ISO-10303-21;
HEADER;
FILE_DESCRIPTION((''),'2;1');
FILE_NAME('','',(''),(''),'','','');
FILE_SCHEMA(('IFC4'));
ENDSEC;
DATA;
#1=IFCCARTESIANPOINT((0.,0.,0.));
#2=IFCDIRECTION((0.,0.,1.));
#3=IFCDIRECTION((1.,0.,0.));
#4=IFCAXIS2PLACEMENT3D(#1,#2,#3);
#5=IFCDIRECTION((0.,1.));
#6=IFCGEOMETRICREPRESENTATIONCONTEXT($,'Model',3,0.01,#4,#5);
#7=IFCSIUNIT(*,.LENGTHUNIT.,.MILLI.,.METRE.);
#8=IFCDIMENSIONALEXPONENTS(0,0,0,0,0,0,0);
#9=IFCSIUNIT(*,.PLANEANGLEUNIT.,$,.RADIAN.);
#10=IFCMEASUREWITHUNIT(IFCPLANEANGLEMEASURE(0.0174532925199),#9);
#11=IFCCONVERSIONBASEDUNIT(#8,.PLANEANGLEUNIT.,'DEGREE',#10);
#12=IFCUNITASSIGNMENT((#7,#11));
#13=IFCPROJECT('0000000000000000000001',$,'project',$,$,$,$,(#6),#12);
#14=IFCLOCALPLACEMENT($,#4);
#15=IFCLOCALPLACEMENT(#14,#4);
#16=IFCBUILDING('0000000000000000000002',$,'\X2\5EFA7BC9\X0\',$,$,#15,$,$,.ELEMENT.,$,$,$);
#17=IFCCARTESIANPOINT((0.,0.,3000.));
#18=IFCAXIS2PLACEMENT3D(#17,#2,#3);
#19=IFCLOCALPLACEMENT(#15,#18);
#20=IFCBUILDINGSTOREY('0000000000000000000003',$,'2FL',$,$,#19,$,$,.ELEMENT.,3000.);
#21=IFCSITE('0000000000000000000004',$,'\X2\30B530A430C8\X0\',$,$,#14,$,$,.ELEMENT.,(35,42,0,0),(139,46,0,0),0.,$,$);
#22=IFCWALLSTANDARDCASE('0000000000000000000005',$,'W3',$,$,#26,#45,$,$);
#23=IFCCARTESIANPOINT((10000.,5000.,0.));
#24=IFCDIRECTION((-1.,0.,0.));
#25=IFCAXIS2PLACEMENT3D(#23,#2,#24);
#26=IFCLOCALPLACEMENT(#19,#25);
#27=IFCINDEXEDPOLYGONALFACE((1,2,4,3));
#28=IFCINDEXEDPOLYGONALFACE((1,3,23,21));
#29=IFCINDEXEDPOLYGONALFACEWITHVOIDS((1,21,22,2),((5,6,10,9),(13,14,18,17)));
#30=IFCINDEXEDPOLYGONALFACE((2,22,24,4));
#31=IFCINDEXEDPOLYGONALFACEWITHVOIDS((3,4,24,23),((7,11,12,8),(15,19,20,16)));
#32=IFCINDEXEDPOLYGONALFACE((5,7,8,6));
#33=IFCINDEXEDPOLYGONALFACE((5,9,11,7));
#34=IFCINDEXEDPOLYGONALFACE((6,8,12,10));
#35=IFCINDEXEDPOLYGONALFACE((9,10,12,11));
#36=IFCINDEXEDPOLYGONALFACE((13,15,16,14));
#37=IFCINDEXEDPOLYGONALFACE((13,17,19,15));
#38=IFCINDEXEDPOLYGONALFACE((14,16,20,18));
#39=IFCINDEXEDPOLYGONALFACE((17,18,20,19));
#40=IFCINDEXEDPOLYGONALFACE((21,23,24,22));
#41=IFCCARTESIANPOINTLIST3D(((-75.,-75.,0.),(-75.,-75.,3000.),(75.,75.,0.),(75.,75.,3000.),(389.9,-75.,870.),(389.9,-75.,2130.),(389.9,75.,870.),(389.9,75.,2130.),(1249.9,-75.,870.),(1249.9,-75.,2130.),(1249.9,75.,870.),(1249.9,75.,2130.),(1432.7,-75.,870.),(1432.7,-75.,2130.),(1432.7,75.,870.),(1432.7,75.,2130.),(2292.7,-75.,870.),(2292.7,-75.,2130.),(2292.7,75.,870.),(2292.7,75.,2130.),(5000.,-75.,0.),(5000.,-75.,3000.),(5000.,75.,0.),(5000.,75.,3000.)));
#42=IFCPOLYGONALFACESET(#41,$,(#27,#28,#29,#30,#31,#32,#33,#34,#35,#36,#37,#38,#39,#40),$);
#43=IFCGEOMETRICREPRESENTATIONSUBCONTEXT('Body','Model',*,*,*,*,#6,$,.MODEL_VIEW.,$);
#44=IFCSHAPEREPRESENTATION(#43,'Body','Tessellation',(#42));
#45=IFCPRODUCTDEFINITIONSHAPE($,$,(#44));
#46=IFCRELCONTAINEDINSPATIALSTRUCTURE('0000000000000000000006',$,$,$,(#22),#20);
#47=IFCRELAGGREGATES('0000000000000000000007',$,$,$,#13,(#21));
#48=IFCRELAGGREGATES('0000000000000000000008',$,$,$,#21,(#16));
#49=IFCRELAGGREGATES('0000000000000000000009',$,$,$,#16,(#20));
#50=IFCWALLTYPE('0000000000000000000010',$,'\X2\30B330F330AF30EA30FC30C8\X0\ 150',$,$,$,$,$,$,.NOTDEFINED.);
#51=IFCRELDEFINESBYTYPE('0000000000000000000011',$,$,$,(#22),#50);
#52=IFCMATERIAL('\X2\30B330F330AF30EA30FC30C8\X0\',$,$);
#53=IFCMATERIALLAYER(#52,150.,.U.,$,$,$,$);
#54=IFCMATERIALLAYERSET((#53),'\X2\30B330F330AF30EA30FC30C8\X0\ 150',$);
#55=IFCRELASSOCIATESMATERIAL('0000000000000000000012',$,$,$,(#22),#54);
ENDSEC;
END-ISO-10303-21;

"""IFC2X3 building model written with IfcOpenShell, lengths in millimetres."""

from ifc_helpers import new_model, entity, si_unit, converted_unit, direction, frame, origin_with_axes, origin_2d_with_axis, place, context, subcontext, project, spatial, polyline, rectangle, outline, extrude, material, layer, layer_set, layer_usage, type_object, element, save


model = new_model("IFC2X3")

# Units and contexts
model_context = context("Model", 3, precision=0.01, world=origin_with_axes(), true_north=direction((0.0, 1.0)))
body_context = subcontext(model_context, "Body", "Model", "MODEL_VIEW")
ifc_project = project(units=[si_unit("LENGTHUNIT", "METRE", prefix="MILLI"), converted_unit("PLANEANGLEUNIT", "DEGREE", entity("IfcPlaneAngleMeasure", 0.0174532925199), si_unit("PLANEANGLEUNIT", "RADIAN"), dimensions=[0, 0, 0, 0, 0, 0, 0])], contexts=[model_context])

# Site, building, storey
site_placement = place(None, origin_with_axes())
site = spatial("IfcSite", under=ifc_project, at=site_placement, Name="サイト", CompositionType="ELEMENT", RefLatitude=(35, 42, 0, 0), RefLongitude=(139, 46, 0, 0), RefElevation=0.0)
building_placement = place(site_placement, origin_with_axes())
building = spatial("IfcBuilding", under=site, at=building_placement, Name="建築", CompositionType="ELEMENT")
storey_placement = place(building_placement, frame((0.0, 0.0, 3000.0), z_axis=(0.0, 0.0, 1.0), x_axis=(1.0, 0.0, 0.0)))
storey = spatial("IfcBuildingStorey", under=building, at=storey_placement, Name="2FL", CompositionType="ELEMENT", Elevation=3000.0)

# Shared definitions
ifc_material_1 = material(Name="コンクリート")

# Shared definitions
ifc_layer_1 = layer(ifc_material_1, 150.0, ventilated="UNKNOWN")
ifc_layer_set_1 = layer_set([ifc_layer_1], Name="コンクリート 150")
wall_type_1 = type_object("IfcWallType", Name="コンクリート 150", PredefinedType="NOTDEFINED")

# Wall, openings
ifc_layer_usage_1 = layer_usage(ifc_layer_set_1, "AXIS2", "POSITIVE", -75.0)
wall_1_placement = place(storey_placement, frame((10000.0, 5000.0, 0.0), z_axis=(0.0, 0.0, 1.0), x_axis=(-1.0, 0.0, 0.0)))
wall_1 = element("IfcWallStandardCase", 1, at=wall_1_placement, inside=storey, type_object=wall_type_1, material=ifc_layer_usage_1, Name="W3", context=body_context, shape_type="SweptSolid", body=[
    extrude(outline(polyline([(-75.0, -75.0), (5000.0, -75.0), (5000.0, 75.0), (75.0, 75.0), (-75.0, -75.0)])), origin_with_axes(), (0.0, 0.0, 1.0), 3000.0),
])
opening_1_placement = place(wall_1_placement, frame((819.9, 0.0, 900.0), z_axis=(0.0, 0.0, 1.0), x_axis=(1.0, 0.0, 0.0)))
element("IfcOpeningElement", 2, at=opening_1_placement, cuts=wall_1, context=body_context, shape_type="SweptSolid", body=[
    extrude(rectangle(XDim=860.0, YDim=1260.0, at=origin_2d_with_axis()), frame((0.0, -195.0, 600.0), z_axis=(0.0, 1.0, 0.0), x_axis=(-1.0, 0.0, 0.0)), (0.0, 0.0, 1.0), 390.0),
])
opening_2_placement = place(wall_1_placement, frame((1862.7, 0.0, 900.0), z_axis=(0.0, 0.0, 1.0), x_axis=(1.0, 0.0, 0.0)))
element("IfcOpeningElement", 3, at=opening_2_placement, cuts=wall_1, context=body_context, shape_type="SweptSolid", body=[
    extrude(rectangle(XDim=860.0, YDim=1260.0, at=origin_2d_with_axis()), frame((0.0, -195.0, 600.0), z_axis=(0.0, 1.0, 0.0), x_axis=(-1.0, 0.0, 0.0)), (0.0, 0.0, 1.0), 390.0),
])

save(model, "model.ifc")
